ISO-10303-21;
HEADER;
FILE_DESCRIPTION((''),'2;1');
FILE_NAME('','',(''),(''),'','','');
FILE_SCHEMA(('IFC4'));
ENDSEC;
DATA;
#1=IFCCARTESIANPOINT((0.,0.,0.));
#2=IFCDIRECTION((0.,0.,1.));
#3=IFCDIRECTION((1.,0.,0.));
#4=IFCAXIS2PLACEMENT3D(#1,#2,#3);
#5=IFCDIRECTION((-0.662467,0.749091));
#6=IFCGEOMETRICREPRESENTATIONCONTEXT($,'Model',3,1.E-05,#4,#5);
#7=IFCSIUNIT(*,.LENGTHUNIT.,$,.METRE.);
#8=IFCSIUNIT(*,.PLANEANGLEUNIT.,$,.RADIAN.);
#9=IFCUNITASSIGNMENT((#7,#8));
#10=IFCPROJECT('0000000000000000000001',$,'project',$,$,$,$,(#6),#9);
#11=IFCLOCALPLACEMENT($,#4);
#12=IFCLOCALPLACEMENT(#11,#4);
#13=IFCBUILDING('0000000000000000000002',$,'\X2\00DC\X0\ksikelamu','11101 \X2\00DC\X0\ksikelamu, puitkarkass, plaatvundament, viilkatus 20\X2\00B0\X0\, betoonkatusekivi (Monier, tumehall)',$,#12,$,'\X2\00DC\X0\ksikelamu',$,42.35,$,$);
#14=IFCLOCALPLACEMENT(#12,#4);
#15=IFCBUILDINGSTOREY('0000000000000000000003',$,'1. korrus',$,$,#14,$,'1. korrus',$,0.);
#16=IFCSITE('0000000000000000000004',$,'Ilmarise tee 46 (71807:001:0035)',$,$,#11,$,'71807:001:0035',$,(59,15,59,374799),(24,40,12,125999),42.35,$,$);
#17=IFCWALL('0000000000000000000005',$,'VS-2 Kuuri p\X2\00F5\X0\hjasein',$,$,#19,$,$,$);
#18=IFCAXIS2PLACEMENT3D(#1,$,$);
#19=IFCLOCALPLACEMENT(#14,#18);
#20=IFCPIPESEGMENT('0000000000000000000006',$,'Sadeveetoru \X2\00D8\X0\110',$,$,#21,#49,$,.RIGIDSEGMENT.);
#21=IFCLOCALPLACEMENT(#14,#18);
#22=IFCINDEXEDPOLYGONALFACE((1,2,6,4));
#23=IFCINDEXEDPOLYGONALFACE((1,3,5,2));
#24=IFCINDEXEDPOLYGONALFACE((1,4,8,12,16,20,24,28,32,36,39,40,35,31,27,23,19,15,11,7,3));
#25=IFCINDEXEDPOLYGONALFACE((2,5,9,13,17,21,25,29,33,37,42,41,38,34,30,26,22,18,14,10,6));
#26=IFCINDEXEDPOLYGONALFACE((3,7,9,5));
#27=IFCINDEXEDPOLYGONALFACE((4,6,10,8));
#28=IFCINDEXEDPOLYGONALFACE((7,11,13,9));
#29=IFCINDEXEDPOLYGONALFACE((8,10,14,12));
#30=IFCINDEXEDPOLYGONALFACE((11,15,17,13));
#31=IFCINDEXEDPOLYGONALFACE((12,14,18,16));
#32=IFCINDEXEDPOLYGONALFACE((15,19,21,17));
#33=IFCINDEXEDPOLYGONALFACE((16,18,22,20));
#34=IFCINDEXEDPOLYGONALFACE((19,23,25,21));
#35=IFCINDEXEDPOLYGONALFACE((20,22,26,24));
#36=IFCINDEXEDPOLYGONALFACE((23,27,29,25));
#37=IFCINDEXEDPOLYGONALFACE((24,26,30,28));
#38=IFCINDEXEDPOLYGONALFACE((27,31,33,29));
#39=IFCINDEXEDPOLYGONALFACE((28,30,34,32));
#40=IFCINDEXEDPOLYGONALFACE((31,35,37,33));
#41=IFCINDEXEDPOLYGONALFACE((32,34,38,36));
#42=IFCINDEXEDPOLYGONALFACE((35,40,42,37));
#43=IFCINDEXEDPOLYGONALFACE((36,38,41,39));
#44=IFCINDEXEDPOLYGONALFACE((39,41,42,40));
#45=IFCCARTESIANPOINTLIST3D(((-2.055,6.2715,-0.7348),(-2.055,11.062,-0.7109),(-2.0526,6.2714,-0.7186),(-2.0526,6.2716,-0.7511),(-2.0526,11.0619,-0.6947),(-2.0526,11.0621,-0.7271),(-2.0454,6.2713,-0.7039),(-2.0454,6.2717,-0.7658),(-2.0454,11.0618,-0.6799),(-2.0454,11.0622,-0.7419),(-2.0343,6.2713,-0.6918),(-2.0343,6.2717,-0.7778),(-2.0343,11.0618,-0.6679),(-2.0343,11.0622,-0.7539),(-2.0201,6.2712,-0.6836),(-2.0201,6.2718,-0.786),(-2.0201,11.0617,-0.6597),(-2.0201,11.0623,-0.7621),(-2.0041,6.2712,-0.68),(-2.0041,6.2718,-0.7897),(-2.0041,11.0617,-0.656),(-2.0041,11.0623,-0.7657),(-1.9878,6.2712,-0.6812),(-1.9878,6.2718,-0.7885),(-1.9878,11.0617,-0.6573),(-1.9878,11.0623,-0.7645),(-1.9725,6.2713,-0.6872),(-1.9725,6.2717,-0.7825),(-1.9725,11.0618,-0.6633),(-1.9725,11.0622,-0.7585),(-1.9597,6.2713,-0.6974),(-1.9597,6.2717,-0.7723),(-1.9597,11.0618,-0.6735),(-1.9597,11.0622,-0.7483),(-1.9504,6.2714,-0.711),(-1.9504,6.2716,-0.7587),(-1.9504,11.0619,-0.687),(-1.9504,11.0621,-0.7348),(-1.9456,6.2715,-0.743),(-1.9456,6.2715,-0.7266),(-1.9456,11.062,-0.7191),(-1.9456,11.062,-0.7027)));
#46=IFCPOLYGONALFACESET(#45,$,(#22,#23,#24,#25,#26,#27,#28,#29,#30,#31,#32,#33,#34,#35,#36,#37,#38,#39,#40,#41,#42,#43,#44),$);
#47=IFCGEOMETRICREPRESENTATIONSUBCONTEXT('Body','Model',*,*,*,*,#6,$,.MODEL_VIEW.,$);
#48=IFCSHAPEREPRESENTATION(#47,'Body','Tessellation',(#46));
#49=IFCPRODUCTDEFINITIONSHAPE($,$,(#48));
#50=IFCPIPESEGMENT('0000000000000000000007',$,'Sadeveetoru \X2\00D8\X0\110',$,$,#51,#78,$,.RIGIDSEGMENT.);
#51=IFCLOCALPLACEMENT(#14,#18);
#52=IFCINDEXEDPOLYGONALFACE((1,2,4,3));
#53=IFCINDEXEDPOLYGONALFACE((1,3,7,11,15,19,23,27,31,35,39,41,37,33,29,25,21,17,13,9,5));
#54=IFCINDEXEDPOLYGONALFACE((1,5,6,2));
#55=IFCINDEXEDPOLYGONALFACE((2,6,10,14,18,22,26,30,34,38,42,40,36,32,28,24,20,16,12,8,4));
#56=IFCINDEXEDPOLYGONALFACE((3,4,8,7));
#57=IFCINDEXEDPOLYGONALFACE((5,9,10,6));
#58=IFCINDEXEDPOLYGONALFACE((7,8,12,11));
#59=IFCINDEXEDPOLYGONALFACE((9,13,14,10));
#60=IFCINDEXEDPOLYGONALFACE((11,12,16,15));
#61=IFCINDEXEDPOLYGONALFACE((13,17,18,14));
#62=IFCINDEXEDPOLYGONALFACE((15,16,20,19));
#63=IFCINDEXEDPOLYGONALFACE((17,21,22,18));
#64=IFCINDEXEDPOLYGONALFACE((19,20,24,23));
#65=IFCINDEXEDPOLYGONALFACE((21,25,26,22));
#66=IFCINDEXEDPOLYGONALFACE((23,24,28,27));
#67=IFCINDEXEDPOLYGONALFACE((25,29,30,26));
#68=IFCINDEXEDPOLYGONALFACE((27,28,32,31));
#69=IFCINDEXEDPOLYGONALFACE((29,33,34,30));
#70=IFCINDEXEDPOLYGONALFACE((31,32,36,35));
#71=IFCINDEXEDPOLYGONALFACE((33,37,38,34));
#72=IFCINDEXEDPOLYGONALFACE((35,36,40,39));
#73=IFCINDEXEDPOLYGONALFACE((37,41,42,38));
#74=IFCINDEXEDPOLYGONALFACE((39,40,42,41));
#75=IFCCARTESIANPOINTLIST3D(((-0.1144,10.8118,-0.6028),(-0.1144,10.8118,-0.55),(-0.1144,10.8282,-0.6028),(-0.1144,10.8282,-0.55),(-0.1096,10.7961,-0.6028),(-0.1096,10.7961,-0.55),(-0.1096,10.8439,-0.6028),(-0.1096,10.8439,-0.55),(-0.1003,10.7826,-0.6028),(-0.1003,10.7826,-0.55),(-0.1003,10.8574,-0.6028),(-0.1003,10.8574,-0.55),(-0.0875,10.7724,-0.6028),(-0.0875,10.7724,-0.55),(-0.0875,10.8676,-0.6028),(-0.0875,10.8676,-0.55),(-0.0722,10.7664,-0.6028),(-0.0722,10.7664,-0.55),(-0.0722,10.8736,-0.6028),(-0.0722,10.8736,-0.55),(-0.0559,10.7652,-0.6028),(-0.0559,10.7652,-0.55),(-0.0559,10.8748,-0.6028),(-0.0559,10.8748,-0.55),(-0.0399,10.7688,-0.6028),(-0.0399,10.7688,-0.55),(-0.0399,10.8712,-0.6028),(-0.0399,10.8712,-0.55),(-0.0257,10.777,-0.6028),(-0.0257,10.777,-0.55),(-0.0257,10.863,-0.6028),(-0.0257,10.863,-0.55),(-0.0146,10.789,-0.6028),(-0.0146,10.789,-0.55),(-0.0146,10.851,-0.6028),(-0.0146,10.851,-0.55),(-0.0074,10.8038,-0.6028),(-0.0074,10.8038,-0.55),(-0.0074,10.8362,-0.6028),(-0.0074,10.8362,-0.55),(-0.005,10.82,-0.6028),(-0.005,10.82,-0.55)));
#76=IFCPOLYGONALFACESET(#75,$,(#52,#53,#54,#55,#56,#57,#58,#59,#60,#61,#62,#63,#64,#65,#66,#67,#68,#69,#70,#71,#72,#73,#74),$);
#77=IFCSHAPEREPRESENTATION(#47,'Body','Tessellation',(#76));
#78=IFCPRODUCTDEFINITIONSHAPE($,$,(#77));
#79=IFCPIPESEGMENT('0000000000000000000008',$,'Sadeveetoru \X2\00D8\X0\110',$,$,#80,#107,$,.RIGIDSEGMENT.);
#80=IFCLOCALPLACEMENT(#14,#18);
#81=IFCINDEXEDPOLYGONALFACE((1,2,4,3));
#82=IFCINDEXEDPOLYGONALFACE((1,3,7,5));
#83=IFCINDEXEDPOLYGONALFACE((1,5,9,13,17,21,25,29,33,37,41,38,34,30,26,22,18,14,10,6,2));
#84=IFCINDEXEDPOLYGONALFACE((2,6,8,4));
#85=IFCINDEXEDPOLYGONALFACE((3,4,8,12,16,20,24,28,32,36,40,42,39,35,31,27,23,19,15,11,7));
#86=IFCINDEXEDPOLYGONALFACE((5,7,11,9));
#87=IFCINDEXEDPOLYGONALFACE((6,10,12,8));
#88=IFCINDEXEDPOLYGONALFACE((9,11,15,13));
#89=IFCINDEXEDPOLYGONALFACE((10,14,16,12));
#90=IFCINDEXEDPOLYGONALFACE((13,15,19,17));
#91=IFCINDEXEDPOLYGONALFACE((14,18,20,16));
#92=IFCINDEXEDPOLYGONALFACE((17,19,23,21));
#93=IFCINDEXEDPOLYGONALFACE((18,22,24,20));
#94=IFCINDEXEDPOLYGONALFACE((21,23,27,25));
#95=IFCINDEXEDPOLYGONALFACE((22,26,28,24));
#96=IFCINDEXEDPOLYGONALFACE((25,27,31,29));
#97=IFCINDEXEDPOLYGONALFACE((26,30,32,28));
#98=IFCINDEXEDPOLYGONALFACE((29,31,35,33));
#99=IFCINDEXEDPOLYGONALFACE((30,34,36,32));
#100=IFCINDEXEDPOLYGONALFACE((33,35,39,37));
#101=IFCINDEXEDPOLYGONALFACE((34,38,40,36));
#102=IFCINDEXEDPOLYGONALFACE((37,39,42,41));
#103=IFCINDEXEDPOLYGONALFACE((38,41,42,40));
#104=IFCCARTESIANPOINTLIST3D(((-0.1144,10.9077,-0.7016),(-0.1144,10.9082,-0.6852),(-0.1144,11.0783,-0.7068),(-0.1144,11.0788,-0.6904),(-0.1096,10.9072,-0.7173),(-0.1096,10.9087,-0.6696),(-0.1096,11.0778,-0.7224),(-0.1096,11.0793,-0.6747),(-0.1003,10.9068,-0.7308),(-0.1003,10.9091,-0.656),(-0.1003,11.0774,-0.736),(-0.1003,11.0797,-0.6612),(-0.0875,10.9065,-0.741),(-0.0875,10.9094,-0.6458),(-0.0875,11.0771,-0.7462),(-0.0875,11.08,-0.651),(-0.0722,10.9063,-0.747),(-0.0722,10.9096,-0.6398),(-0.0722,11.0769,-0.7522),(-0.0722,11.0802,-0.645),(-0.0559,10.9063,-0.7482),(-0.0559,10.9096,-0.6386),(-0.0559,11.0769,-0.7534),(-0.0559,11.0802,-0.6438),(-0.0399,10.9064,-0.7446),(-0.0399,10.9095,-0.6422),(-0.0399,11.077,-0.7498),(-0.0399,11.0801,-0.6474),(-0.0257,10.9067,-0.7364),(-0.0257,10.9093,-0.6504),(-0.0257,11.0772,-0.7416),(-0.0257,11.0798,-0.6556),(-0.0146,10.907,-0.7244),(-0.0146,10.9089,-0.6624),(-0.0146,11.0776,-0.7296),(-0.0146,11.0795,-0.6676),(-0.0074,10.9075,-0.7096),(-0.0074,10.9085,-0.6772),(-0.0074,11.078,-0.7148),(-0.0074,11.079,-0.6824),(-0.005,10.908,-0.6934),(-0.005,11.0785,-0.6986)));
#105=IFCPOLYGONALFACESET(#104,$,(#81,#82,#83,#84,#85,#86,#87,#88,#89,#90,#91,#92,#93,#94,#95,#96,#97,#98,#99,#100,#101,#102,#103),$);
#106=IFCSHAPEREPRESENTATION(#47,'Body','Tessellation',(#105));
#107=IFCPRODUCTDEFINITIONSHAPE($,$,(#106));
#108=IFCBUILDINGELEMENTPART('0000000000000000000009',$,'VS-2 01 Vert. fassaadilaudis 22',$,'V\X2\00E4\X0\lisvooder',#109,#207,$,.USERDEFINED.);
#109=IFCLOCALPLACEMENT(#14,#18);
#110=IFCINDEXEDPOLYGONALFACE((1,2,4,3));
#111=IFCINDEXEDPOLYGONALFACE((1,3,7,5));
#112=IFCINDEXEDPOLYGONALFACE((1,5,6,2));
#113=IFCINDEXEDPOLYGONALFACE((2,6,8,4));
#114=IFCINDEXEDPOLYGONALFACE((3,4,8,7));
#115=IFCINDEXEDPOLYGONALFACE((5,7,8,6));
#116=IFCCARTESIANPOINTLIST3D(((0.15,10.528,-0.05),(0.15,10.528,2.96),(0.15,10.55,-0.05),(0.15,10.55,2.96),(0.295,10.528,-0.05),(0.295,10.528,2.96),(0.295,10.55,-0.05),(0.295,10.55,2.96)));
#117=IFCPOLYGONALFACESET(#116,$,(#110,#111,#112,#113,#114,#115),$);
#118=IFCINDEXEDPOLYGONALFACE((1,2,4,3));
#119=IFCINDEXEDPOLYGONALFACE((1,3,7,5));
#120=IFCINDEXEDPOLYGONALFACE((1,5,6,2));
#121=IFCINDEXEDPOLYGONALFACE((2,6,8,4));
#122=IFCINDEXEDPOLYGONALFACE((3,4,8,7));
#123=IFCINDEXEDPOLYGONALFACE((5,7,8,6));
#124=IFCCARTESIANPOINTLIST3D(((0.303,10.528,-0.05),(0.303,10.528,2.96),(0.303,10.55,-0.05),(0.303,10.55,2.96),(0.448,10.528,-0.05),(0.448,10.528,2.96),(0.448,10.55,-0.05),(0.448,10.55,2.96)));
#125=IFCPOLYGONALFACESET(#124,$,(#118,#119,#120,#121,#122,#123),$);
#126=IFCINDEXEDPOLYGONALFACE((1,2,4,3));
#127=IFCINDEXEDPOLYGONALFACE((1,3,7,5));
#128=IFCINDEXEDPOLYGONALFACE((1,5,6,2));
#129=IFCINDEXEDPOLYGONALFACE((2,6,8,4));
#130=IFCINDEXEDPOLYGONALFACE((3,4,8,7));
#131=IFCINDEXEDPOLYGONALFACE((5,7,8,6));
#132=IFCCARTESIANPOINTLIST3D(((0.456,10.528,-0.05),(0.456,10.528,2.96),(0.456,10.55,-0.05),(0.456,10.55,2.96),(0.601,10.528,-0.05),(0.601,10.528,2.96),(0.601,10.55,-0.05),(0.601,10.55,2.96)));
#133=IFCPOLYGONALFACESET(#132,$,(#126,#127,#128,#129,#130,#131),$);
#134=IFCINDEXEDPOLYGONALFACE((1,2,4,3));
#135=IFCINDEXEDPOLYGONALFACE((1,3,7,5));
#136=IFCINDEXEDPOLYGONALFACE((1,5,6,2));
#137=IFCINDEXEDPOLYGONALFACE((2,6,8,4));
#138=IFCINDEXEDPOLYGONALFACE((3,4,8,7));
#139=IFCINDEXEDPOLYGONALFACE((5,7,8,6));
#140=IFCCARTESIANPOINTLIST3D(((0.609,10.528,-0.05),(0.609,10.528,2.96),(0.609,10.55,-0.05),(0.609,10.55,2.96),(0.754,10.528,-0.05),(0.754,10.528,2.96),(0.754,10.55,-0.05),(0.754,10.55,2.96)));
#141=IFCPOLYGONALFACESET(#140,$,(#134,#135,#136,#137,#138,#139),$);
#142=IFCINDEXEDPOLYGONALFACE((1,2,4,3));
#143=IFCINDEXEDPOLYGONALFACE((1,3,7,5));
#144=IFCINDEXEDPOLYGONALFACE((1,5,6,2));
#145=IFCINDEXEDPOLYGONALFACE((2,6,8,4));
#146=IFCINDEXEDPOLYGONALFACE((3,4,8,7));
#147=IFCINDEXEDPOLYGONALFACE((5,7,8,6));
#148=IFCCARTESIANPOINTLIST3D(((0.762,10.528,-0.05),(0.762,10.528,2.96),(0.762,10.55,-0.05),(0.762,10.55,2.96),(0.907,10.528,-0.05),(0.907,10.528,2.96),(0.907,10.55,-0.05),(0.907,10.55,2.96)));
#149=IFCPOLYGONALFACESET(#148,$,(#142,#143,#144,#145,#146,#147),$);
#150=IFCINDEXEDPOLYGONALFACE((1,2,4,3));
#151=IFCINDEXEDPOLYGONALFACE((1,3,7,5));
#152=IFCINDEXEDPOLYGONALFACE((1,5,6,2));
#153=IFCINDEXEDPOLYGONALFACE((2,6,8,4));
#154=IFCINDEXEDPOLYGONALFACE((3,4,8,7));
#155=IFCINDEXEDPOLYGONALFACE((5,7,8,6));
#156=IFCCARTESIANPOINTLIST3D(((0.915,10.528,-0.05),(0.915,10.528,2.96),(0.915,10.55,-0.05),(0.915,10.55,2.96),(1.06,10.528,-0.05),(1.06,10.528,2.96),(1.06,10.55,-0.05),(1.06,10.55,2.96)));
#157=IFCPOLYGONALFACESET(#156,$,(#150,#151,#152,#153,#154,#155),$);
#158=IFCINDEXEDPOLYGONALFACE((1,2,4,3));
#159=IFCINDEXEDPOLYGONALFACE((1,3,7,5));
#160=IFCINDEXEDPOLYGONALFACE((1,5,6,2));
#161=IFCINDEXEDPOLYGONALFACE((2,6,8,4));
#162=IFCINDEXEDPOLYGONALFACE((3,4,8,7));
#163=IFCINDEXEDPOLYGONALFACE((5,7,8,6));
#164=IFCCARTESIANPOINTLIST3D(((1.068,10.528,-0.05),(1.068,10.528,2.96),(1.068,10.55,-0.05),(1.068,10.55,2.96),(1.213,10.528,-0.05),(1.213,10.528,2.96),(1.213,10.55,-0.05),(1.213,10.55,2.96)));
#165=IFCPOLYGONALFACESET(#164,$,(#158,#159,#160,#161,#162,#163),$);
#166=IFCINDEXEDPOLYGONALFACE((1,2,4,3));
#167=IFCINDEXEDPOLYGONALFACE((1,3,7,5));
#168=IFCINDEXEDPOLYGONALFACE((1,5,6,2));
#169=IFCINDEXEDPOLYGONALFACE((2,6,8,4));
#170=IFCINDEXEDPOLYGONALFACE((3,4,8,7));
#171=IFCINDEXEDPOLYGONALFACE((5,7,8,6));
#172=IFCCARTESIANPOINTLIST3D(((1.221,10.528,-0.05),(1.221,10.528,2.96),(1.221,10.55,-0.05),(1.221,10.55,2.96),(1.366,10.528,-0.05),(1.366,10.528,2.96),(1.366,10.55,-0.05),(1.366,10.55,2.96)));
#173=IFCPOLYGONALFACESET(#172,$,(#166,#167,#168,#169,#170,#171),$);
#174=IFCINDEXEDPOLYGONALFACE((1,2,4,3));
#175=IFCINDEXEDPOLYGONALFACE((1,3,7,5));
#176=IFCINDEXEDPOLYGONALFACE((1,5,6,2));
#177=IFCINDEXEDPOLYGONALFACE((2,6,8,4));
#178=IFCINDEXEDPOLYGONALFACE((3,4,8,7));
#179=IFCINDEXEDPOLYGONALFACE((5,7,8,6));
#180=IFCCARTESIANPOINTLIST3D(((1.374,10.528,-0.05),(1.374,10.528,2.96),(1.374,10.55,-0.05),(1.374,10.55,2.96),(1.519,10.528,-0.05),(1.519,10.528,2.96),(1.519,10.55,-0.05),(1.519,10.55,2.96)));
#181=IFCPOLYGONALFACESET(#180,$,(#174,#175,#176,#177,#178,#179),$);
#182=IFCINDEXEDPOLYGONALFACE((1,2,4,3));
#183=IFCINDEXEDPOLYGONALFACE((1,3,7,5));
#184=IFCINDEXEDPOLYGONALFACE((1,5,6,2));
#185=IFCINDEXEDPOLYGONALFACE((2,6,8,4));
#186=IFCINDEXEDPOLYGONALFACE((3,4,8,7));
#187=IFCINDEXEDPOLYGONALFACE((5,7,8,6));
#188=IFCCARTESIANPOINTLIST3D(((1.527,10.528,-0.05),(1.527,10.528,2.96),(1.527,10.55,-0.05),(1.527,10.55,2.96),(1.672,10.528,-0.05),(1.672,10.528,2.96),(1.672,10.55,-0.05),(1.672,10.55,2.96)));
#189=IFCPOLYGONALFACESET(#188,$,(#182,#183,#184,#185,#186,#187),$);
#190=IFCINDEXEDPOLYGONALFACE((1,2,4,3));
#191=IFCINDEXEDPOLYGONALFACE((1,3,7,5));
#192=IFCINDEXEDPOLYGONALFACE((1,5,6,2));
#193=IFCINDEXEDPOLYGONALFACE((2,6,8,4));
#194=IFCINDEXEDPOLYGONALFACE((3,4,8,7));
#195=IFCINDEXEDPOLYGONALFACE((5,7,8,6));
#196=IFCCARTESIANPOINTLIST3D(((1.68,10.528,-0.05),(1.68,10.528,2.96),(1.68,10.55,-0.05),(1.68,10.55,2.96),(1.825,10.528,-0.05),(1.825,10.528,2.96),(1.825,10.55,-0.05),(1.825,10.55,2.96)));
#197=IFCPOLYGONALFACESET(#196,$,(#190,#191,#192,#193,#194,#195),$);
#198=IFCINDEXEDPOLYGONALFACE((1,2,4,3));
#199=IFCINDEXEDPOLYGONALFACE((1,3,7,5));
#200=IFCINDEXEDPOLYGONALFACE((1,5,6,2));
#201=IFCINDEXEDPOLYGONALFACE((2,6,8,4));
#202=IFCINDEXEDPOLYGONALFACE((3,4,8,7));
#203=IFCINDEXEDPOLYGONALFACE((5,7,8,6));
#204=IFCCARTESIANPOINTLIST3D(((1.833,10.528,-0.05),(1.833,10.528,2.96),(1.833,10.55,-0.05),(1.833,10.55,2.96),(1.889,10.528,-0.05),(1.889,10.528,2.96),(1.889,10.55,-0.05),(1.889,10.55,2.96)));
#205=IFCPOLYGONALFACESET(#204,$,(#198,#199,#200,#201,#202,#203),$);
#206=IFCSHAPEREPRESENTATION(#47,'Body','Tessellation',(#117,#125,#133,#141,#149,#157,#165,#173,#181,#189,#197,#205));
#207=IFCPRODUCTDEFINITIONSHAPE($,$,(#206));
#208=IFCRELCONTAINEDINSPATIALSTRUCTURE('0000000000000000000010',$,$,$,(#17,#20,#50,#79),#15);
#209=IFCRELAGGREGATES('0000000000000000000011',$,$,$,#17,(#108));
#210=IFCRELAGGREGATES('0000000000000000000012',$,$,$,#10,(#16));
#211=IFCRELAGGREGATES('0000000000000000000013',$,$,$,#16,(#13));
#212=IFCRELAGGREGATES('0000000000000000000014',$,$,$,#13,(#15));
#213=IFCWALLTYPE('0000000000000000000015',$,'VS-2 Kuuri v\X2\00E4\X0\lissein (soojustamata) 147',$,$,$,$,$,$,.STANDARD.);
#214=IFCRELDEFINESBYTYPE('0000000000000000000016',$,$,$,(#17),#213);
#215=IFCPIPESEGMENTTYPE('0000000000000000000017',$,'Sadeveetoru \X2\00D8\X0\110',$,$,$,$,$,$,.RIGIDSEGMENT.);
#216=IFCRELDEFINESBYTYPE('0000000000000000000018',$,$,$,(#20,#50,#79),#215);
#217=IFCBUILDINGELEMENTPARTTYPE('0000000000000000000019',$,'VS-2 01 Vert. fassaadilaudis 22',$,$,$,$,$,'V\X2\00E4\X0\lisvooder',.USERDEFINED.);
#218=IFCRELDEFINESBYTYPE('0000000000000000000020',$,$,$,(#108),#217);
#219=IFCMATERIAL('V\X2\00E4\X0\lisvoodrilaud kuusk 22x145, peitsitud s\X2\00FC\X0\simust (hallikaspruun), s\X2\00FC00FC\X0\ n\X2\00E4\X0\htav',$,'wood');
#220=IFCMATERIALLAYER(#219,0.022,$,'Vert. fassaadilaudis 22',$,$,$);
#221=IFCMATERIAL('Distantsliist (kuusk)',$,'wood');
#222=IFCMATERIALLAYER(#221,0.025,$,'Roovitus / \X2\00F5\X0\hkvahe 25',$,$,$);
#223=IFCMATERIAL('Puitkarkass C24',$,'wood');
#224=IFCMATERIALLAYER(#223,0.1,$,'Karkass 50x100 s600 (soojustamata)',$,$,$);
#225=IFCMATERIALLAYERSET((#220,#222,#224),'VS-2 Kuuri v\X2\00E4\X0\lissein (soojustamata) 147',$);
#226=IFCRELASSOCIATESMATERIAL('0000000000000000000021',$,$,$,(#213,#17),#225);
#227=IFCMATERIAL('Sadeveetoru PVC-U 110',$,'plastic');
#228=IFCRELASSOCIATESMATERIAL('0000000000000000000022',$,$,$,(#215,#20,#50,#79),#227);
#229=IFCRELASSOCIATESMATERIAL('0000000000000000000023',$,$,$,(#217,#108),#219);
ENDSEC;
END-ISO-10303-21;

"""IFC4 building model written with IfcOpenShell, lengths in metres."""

from ifc_helpers import new_model, si_unit, direction, frame, origin_with_axes, place, context, subcontext, project, spatial, indexed_curve, circle, outline, extrude, material, layer, layer_set, layer_usage, type_object, element, aggregate, save


model = new_model("IFC4")

# Units and contexts
model_context = context("Model", 3, precision=1e-05, world=origin_with_axes(), true_north=direction((-0.662467, 0.749091)))
body_context = subcontext(model_context, "Body", "Model", "MODEL_VIEW")
ifc_project = project(units=[si_unit("LENGTHUNIT", "METRE"), si_unit("PLANEANGLEUNIT", "RADIAN")], contexts=[model_context])

# Site, building, storey
site_placement = place(None, origin_with_axes())
site = spatial("IfcSite", under=ifc_project, at=site_placement, Name="Ilmarise tee 46 (71807:001:0035)", LongName="71807:001:0035", RefLatitude=(59, 15, 59, 374799), RefLongitude=(24, 40, 12, 125999), RefElevation=42.35)
building_placement = place(site_placement, origin_with_axes())
building = spatial("IfcBuilding", under=site, at=building_placement, Name="Üksikelamu", Description="11101 Üksikelamu, puitkarkass, plaatvundament, viilkatus 20°, betoonkatusekivi (Monier, tumehall)", LongName="Üksikelamu", ElevationOfRefHeight=42.35)
storey_placement = place(building_placement, origin_with_axes())
storey = spatial("IfcBuildingStorey", under=building, at=storey_placement, Name="1. korrus", LongName="1. korrus", Elevation=0.0)

# Wall
ifc_material_1 = material(Name="Välisvoodrilaud kuusk 22x145, peitsitud süsimust (hallikaspruun), süü nähtav", Category="wood")
ifc_layer_1 = layer(ifc_material_1, 0.022, Name="Vert. fassaadilaudis 22")
ifc_material_2 = material(Name="Distantsliist (kuusk)", Category="wood")
ifc_layer_2 = layer(ifc_material_2, 0.025, Name="Roovitus / õhkvahe 25")
ifc_material_3 = material(Name="Puitkarkass C24", Category="wood")
ifc_layer_3 = layer(ifc_material_3, 0.1, Name="Karkass 50x100 s600 (soojustamata)")
ifc_layer_set = layer_set([ifc_layer_1, ifc_layer_2, ifc_layer_3], Name="VS-2 Kuuri välissein (soojustamata) 147")
ifc_layer_usage = layer_usage(ifc_layer_set, "AXIS2", "NEGATIVE", 0.0)
wall_type = type_object("IfcWallType", Name="VS-2 Kuuri välissein (soojustamata) 147", PredefinedType="STANDARD", material=ifc_layer_set)
wall_placement = place(storey_placement, frame((0.0, 10.55, 0.0), z_axis=(0.0, 0.0, 1.0), x_axis=(1.0, 0.0, 0.0)))
wall = element("IfcWall", 1, at=wall_placement, inside=storey, type_object=wall_type, material=ifc_layer_usage, Name="VS-2 Kuuri põhjasein")

# Shared definitions
ifc_material_4 = material(Name="Sadeveetoru PVC-U 110", Category="plastic")

# Pipe segments
pipe_segment_type_1 = type_object("IfcPipeSegmentType", Name="Sadeveetoru Ø110", PredefinedType="RIGIDSEGMENT", material=ifc_material_4)
pipe_segment_1_placement = place(storey_placement, frame((-2.0, 11.062, -0.7109), z_axis=(0.0, -0.999988, -0.005), x_axis=(-1.0, 0.0, 0.0)))
element("IfcPipeSegment", 2, at=pipe_segment_1_placement, inside=storey, type_object=pipe_segment_type_1, material=ifc_material_4, Name="Sadeveetoru Ø110", PredefinedType="RIGIDSEGMENT", context=body_context, shape_type="SweptSolid", body=[
    extrude(circle(Radius=0.055), origin_with_axes(), (0.0, 0.0, 1.0), 4.7906),
])
pipe_segment_2_placement = place(storey_placement, frame((-0.06, 10.82, -0.55), z_axis=(0.0, 0.0, -1.0), x_axis=(1.0, 0.0, 0.0)))
element("IfcPipeSegment", 3, at=pipe_segment_2_placement, inside=storey, type_object=pipe_segment_type_1, material=ifc_material_4, Name="Sadeveetoru Ø110", PredefinedType="RIGIDSEGMENT", context=body_context, shape_type="SweptSolid", body=[
    extrude(circle(Radius=0.055), origin_with_axes(), (0.0, 0.0, 1.0), 0.0527),
])
pipe_segment_3_placement = place(storey_placement, frame((-0.06, 10.908, -0.6934), z_axis=(0.0, 0.999541, -0.030289), x_axis=(1.0, 0.0, 0.0)))
element("IfcPipeSegment", 4, at=pipe_segment_3_placement, inside=storey, type_object=pipe_segment_type_1, material=ifc_material_4, Name="Sadeveetoru Ø110", PredefinedType="RIGIDSEGMENT", context=body_context, shape_type="SweptSolid", body=[
    extrude(circle(Radius=0.055), origin_with_axes(), (0.0, 0.0, 1.0), 0.1707),
])

# Building element part
building_element_part_type = type_object("IfcBuildingElementPartType", Name="VS-2 01 Vert. fassaadilaudis 22", ElementType="Välisvooder", PredefinedType="USERDEFINED", material=ifc_material_1)
building_element_part_placement = place(wall_placement, origin_with_axes())
building_element_part = element("IfcBuildingElementPart", 5, at=building_element_part_placement, type_object=building_element_part_type, material=ifc_material_1, Name="VS-2 01 Vert. fassaadilaudis 22", ObjectType="Välisvooder", PredefinedType="USERDEFINED", context=body_context, shape_type="SweptSolid", body=[
    extrude(outline(indexed_curve([(0.295, -0.05), (0.15, -0.05), (0.15, 2.96), (0.295, 2.96), (0.295, -0.05)], self_intersect=False)), frame((0.0, 0.0, 0.0), z_axis=(0.0, -1.0, 0.0), x_axis=(1.0, 0.0, 0.0)), (0.0, 0.0, 1.0), 0.022),
    extrude(outline(indexed_curve([(0.448, -0.05), (0.303, -0.05), (0.303, 2.96), (0.448, 2.96), (0.448, -0.05)], self_intersect=False)), frame((0.0, 0.0, 0.0), z_axis=(0.0, -1.0, 0.0), x_axis=(1.0, 0.0, 0.0)), (0.0, 0.0, 1.0), 0.022),
    extrude(outline(indexed_curve([(0.601, -0.05), (0.456, -0.05), (0.456, 2.96), (0.601, 2.96), (0.601, -0.05)], self_intersect=False)), frame((0.0, 0.0, 0.0), z_axis=(0.0, -1.0, 0.0), x_axis=(1.0, 0.0, 0.0)), (0.0, 0.0, 1.0), 0.022),
    extrude(outline(indexed_curve([(0.754, -0.05), (0.609, -0.05), (0.609, 2.96), (0.754, 2.96), (0.754, -0.05)], self_intersect=False)), frame((0.0, 0.0, 0.0), z_axis=(0.0, -1.0, 0.0), x_axis=(1.0, 0.0, 0.0)), (0.0, 0.0, 1.0), 0.022),
    extrude(outline(indexed_curve([(0.907, -0.05), (0.762, -0.05), (0.762, 2.96), (0.907, 2.96), (0.907, -0.05)], self_intersect=False)), frame((0.0, 0.0, 0.0), z_axis=(0.0, -1.0, 0.0), x_axis=(1.0, 0.0, 0.0)), (0.0, 0.0, 1.0), 0.022),
    extrude(outline(indexed_curve([(1.06, -0.05), (0.915, -0.05), (0.915, 2.96), (1.06, 2.96), (1.06, -0.05)], self_intersect=False)), frame((0.0, 0.0, 0.0), z_axis=(0.0, -1.0, 0.0), x_axis=(1.0, 0.0, 0.0)), (0.0, 0.0, 1.0), 0.022),
    extrude(outline(indexed_curve([(1.213, -0.05), (1.068, -0.05), (1.068, 2.96), (1.213, 2.96), (1.213, -0.05)], self_intersect=False)), frame((0.0, 0.0, 0.0), z_axis=(0.0, -1.0, 0.0), x_axis=(1.0, 0.0, 0.0)), (0.0, 0.0, 1.0), 0.022),
    extrude(outline(indexed_curve([(1.366, -0.05), (1.221, -0.05), (1.221, 2.96), (1.366, 2.96), (1.366, -0.05)], self_intersect=False)), frame((0.0, 0.0, 0.0), z_axis=(0.0, -1.0, 0.0), x_axis=(1.0, 0.0, 0.0)), (0.0, 0.0, 1.0), 0.022),
    extrude(outline(indexed_curve([(1.519, -0.05), (1.374, -0.05), (1.374, 2.96), (1.519, 2.96), (1.519, -0.05)], self_intersect=False)), frame((0.0, 0.0, 0.0), z_axis=(0.0, -1.0, 0.0), x_axis=(1.0, 0.0, 0.0)), (0.0, 0.0, 1.0), 0.022),
    extrude(outline(indexed_curve([(1.672, -0.05), (1.527, -0.05), (1.527, 2.96), (1.672, 2.96), (1.672, -0.05)], self_intersect=False)), frame((0.0, 0.0, 0.0), z_axis=(0.0, -1.0, 0.0), x_axis=(1.0, 0.0, 0.0)), (0.0, 0.0, 1.0), 0.022),
    extrude(outline(indexed_curve([(1.825, -0.05), (1.68, -0.05), (1.68, 2.96), (1.825, 2.96), (1.825, -0.05)], self_intersect=False)), frame((0.0, 0.0, 0.0), z_axis=(0.0, -1.0, 0.0), x_axis=(1.0, 0.0, 0.0)), (0.0, 0.0, 1.0), 0.022),
    extrude(outline(indexed_curve([(1.889, -0.05), (1.833, -0.05), (1.833, 2.96), (1.889, 2.96), (1.889, -0.05)], self_intersect=False)), frame((0.0, 0.0, 0.0), z_axis=(0.0, -1.0, 0.0), x_axis=(1.0, 0.0, 0.0)), (0.0, 0.0, 1.0), 0.022),
])
aggregate(wall, [building_element_part])

save(model, "model.ifc")
